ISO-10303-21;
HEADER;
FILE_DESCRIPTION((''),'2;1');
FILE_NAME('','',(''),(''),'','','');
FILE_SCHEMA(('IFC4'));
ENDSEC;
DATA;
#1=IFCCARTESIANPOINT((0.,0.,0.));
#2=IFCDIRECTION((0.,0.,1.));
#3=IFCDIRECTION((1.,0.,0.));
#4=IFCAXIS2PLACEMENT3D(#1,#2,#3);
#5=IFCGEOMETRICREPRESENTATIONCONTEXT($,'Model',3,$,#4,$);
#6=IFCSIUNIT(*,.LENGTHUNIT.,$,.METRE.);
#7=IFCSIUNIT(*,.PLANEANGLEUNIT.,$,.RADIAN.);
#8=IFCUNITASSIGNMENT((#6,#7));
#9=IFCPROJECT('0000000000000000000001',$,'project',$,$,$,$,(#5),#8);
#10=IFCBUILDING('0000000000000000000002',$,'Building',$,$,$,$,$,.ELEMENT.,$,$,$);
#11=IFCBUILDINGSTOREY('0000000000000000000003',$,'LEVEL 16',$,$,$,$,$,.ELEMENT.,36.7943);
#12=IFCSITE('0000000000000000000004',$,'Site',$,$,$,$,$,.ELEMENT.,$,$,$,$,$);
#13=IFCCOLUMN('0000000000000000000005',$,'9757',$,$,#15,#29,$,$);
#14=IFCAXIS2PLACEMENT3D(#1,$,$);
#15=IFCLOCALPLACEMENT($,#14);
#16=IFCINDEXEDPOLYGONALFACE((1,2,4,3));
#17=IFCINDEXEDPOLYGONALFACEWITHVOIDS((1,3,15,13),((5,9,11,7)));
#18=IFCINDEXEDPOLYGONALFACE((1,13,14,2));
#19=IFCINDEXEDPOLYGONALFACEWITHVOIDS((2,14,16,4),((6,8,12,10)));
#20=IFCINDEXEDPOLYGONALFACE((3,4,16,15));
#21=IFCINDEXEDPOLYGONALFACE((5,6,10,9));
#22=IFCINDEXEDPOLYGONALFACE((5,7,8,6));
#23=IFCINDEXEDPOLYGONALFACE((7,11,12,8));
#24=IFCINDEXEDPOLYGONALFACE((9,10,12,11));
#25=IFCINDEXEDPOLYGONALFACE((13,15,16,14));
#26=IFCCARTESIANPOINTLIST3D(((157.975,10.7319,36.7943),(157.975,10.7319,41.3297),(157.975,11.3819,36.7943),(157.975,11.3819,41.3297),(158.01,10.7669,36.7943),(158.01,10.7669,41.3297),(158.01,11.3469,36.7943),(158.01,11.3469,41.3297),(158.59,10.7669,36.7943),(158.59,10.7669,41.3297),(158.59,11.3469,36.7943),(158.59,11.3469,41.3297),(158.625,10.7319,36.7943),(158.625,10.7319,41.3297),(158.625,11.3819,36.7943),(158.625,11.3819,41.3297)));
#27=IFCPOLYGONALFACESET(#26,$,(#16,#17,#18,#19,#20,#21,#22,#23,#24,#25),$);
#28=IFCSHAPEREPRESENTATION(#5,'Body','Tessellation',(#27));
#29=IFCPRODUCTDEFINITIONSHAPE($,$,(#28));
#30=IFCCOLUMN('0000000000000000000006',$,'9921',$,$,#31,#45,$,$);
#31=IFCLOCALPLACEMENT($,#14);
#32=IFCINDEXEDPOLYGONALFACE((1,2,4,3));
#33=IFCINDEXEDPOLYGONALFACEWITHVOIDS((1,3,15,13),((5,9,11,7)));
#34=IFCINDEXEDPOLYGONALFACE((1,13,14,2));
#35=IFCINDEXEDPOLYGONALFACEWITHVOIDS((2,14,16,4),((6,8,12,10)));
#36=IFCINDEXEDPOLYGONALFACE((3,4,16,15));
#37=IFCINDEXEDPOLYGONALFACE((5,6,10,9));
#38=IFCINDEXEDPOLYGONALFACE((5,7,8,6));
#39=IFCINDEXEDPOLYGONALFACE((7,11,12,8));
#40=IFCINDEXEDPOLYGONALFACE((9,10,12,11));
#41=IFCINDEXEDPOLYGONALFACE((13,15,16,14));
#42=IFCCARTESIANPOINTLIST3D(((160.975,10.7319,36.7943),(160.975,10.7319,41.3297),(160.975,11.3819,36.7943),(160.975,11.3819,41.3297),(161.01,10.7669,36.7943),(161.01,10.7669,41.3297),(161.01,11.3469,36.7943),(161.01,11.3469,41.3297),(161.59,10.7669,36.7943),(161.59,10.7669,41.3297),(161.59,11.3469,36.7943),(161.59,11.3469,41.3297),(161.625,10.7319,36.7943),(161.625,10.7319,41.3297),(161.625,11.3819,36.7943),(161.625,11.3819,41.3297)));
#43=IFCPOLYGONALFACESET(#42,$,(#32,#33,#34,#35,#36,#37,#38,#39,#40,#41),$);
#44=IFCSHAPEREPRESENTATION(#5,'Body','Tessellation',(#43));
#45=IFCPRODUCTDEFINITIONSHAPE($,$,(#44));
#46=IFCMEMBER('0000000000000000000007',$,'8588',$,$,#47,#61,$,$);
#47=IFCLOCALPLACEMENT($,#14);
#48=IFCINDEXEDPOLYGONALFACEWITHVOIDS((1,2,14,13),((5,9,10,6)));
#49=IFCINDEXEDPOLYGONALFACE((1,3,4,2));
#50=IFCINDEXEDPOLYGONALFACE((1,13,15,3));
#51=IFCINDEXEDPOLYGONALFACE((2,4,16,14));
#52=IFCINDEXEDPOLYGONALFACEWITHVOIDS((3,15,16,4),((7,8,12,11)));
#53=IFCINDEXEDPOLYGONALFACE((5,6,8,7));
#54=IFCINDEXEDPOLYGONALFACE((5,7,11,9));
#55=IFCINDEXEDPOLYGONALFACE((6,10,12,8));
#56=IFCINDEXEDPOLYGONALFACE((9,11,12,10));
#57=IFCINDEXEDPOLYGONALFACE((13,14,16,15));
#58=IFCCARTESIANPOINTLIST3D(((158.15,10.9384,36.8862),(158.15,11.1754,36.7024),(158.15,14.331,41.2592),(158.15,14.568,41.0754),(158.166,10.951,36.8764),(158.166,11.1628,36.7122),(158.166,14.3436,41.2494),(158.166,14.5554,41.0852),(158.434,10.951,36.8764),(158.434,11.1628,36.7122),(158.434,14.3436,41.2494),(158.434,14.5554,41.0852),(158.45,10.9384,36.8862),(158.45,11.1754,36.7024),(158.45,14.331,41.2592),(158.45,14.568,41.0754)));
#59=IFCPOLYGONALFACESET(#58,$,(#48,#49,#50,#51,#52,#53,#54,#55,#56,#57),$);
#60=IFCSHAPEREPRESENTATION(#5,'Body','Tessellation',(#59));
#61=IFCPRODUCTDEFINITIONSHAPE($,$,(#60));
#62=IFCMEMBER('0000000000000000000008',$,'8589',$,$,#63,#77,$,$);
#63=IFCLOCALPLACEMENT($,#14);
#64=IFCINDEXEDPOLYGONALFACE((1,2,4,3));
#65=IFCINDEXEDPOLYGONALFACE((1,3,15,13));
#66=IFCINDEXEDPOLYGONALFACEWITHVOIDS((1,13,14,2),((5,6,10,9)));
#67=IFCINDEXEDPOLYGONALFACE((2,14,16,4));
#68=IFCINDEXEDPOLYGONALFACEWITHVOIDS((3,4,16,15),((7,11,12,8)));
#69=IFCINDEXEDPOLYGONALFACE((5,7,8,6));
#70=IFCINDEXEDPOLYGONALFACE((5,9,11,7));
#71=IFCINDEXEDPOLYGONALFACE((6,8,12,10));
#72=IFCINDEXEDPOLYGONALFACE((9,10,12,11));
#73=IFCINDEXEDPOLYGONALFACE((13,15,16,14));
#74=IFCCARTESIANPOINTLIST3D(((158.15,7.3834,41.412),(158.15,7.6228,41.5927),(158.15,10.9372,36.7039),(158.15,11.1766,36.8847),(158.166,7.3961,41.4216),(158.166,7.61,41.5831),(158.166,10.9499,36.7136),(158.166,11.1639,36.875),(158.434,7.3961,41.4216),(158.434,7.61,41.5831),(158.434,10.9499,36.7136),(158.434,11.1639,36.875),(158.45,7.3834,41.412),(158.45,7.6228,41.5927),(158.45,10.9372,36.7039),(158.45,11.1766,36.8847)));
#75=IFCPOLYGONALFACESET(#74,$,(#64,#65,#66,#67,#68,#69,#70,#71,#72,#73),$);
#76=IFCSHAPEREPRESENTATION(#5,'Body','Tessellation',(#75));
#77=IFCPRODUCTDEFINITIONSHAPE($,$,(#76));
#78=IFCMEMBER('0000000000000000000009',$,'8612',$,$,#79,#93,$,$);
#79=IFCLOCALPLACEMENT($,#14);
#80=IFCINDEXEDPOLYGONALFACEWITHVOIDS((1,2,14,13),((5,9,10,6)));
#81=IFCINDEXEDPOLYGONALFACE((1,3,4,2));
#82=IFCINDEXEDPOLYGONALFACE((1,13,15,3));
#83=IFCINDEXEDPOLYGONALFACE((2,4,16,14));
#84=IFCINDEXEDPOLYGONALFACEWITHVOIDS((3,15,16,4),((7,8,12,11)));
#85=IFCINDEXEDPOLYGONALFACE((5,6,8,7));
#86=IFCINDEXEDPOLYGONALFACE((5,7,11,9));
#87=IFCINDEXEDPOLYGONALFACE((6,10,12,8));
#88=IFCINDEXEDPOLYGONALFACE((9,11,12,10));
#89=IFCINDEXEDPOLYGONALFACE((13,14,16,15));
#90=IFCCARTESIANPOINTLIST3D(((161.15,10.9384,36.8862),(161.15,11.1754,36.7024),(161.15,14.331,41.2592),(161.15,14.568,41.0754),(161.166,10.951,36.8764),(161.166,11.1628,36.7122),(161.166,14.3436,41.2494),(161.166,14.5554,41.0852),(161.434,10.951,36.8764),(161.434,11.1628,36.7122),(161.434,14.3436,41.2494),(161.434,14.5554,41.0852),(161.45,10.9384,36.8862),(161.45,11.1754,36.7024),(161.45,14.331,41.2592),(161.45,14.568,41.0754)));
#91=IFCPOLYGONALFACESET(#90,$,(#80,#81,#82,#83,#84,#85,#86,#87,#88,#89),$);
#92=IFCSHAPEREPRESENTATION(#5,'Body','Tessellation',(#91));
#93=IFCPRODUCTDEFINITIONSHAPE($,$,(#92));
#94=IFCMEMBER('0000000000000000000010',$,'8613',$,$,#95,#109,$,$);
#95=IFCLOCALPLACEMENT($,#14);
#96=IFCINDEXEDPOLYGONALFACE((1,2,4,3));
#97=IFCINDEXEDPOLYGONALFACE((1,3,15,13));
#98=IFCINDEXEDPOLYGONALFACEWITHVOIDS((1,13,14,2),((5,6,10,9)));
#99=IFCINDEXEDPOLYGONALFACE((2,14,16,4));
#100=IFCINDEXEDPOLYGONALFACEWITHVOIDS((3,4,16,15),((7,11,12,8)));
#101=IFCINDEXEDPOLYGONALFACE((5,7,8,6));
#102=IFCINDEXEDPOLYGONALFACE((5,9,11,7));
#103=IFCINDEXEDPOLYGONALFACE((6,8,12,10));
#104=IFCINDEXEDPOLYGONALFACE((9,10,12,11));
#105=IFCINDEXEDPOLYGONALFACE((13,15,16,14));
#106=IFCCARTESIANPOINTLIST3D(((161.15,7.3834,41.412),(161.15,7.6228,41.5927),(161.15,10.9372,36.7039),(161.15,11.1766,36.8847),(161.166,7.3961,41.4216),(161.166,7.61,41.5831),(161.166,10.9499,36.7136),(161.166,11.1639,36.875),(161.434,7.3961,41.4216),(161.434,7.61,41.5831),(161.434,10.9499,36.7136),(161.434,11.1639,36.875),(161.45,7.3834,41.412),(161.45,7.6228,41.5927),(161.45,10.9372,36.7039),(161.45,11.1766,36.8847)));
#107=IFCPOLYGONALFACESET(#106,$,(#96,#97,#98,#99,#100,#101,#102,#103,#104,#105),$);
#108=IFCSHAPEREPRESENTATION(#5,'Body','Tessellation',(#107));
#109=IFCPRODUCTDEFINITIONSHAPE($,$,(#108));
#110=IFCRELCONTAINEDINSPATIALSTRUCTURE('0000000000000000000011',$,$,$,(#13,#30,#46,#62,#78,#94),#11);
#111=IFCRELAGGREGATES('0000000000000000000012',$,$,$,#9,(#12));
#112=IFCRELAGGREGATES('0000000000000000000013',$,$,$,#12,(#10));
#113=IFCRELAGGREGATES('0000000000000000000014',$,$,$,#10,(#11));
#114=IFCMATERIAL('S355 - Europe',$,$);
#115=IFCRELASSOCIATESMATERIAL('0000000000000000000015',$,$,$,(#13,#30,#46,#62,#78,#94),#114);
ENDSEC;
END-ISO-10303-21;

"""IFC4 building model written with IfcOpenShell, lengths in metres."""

from ifc_helpers import new_model, si_unit, frame, origin_with_axes, origin_2d_with_axis, place, context, project, spatial, hollow_rectangle, extrude, material, material_profile, profile_set, profile_usage, element, save


model = new_model("IFC4")

# Units and contexts
model_context = context("Model", 3, world=origin_with_axes())
ifc_project = project(units=[si_unit("LENGTHUNIT", "METRE"), si_unit("PLANEANGLEUNIT", "RADIAN")], contexts=[model_context])

# Site, building, storey
site = spatial("IfcSite", under=ifc_project, Name="Site", CompositionType="ELEMENT")
building = spatial("IfcBuilding", under=site, Name="Building", CompositionType="ELEMENT")
storey = spatial("IfcBuildingStorey", under=building, Name="LEVEL 16", CompositionType="ELEMENT", Elevation=36.7943)

# Columns
ifc_material = material(Name="S355 - Europe")
ifc_material_profile_1 = material_profile(ifc_material, hollow_rectangle(XDim=0.65, YDim=0.65, WallThickness=0.035, at=origin_2d_with_axis()))
ifc_profile_set_1 = profile_set([ifc_material_profile_1])
ifc_profile_usage_1 = profile_usage(ifc_profile_set_1, cardinal=10)
column_1_placement = place(None, frame((158.3, 11.0569, 36.7943), z_axis=(0.0, 0.0, 1.0), x_axis=(0.0, -1.0, 0.0)))
element("IfcColumn", 1, at=column_1_placement, inside=storey, material=ifc_profile_usage_1, Name="9757", context=model_context, shape_type="SweptSolid", body=[
    extrude(hollow_rectangle(XDim=0.65, YDim=0.65, WallThickness=0.035, at=origin_2d_with_axis()), origin_with_axes(), (0.0, 0.0, 1.0), 4.5354),
])
ifc_material_profile_2 = material_profile(ifc_material, hollow_rectangle(XDim=0.65, YDim=0.65, WallThickness=0.035, at=origin_2d_with_axis()))
ifc_profile_set_2 = profile_set([ifc_material_profile_2])
ifc_profile_usage_2 = profile_usage(ifc_profile_set_2, cardinal=10)
column_2_placement = place(None, frame((161.3, 11.0569, 36.7943), z_axis=(0.0, 0.0, 1.0), x_axis=(0.0, -1.0, 0.0)))
element("IfcColumn", 2, at=column_2_placement, inside=storey, material=ifc_profile_usage_2, Name="9921", context=model_context, shape_type="SweptSolid", body=[
    extrude(hollow_rectangle(XDim=0.65, YDim=0.65, WallThickness=0.035, at=origin_2d_with_axis()), origin_with_axes(), (0.0, 0.0, 1.0), 4.5354),
])

# Members
ifc_material_profile_3 = material_profile(ifc_material, hollow_rectangle(XDim=0.3, YDim=0.3, WallThickness=0.016, at=origin_2d_with_axis()))
ifc_profile_set_3 = profile_set([ifc_material_profile_3])
ifc_profile_usage_3 = profile_usage(ifc_profile_set_3, cardinal=10)
member_1_placement = place(None, frame((158.3, 14.4495, 41.1673), z_axis=(0.0, -0.612969, -0.790107), x_axis=(1.0, 0.0, 0.0)))
element("IfcMember", 3, at=member_1_placement, inside=storey, material=ifc_profile_usage_3, Name="8588", context=model_context, shape_type="SweptSolid", body=[
    extrude(hollow_rectangle(XDim=0.3, YDim=0.3, WallThickness=0.016, at=origin_2d_with_axis()), origin_with_axes(), (0.0, 0.0, 1.0), 5.5347),
])
ifc_material_profile_4 = material_profile(ifc_material, hollow_rectangle(XDim=0.3, YDim=0.3, WallThickness=0.016, at=origin_2d_with_axis()))
ifc_profile_set_4 = profile_set([ifc_material_profile_4])
ifc_profile_usage_4 = profile_usage(ifc_profile_set_4, cardinal=10)
member_2_placement = place(None, frame((158.3, 11.0569, 36.7943), z_axis=(0.0, -0.602472, 0.79814), x_axis=(1.0, 0.0, 0.0)))
element("IfcMember", 4, at=member_2_placement, inside=storey, material=ifc_profile_usage_4, Name="8589", context=model_context, shape_type="SweptSolid", body=[
    extrude(hollow_rectangle(XDim=0.3, YDim=0.3, WallThickness=0.016, at=origin_2d_with_axis()), origin_with_axes(), (0.0, 0.0, 1.0), 5.8987),
])
ifc_material_profile_5 = material_profile(ifc_material, hollow_rectangle(XDim=0.3, YDim=0.3, WallThickness=0.016, at=origin_2d_with_axis()))
ifc_profile_set_5 = profile_set([ifc_material_profile_5])
ifc_profile_usage_5 = profile_usage(ifc_profile_set_5, cardinal=10)
member_3_placement = place(None, frame((161.3, 14.4495, 41.1673), z_axis=(0.0, -0.612969, -0.790107), x_axis=(1.0, 0.0, 0.0)))
element("IfcMember", 5, at=member_3_placement, inside=storey, material=ifc_profile_usage_5, Name="8612", context=model_context, shape_type="SweptSolid", body=[
    extrude(hollow_rectangle(XDim=0.3, YDim=0.3, WallThickness=0.016, at=origin_2d_with_axis()), origin_with_axes(), (0.0, 0.0, 1.0), 5.5347),
])
ifc_material_profile_6 = material_profile(ifc_material, hollow_rectangle(XDim=0.3, YDim=0.3, WallThickness=0.016, at=origin_2d_with_axis()))
ifc_profile_set_6 = profile_set([ifc_material_profile_6])
ifc_profile_usage_6 = profile_usage(ifc_profile_set_6, cardinal=10)
member_4_placement = place(None, frame((161.3, 11.0569, 36.7943), z_axis=(0.0, -0.602472, 0.79814), x_axis=(1.0, 0.0, 0.0)))
element("IfcMember", 6, at=member_4_placement, inside=storey, material=ifc_profile_usage_6, Name="8613", context=model_context, shape_type="SweptSolid", body=[
    extrude(hollow_rectangle(XDim=0.3, YDim=0.3, WallThickness=0.016, at=origin_2d_with_axis()), origin_with_axes(), (0.0, 0.0, 1.0), 5.8987),
])

save(model, "model.ifc")
